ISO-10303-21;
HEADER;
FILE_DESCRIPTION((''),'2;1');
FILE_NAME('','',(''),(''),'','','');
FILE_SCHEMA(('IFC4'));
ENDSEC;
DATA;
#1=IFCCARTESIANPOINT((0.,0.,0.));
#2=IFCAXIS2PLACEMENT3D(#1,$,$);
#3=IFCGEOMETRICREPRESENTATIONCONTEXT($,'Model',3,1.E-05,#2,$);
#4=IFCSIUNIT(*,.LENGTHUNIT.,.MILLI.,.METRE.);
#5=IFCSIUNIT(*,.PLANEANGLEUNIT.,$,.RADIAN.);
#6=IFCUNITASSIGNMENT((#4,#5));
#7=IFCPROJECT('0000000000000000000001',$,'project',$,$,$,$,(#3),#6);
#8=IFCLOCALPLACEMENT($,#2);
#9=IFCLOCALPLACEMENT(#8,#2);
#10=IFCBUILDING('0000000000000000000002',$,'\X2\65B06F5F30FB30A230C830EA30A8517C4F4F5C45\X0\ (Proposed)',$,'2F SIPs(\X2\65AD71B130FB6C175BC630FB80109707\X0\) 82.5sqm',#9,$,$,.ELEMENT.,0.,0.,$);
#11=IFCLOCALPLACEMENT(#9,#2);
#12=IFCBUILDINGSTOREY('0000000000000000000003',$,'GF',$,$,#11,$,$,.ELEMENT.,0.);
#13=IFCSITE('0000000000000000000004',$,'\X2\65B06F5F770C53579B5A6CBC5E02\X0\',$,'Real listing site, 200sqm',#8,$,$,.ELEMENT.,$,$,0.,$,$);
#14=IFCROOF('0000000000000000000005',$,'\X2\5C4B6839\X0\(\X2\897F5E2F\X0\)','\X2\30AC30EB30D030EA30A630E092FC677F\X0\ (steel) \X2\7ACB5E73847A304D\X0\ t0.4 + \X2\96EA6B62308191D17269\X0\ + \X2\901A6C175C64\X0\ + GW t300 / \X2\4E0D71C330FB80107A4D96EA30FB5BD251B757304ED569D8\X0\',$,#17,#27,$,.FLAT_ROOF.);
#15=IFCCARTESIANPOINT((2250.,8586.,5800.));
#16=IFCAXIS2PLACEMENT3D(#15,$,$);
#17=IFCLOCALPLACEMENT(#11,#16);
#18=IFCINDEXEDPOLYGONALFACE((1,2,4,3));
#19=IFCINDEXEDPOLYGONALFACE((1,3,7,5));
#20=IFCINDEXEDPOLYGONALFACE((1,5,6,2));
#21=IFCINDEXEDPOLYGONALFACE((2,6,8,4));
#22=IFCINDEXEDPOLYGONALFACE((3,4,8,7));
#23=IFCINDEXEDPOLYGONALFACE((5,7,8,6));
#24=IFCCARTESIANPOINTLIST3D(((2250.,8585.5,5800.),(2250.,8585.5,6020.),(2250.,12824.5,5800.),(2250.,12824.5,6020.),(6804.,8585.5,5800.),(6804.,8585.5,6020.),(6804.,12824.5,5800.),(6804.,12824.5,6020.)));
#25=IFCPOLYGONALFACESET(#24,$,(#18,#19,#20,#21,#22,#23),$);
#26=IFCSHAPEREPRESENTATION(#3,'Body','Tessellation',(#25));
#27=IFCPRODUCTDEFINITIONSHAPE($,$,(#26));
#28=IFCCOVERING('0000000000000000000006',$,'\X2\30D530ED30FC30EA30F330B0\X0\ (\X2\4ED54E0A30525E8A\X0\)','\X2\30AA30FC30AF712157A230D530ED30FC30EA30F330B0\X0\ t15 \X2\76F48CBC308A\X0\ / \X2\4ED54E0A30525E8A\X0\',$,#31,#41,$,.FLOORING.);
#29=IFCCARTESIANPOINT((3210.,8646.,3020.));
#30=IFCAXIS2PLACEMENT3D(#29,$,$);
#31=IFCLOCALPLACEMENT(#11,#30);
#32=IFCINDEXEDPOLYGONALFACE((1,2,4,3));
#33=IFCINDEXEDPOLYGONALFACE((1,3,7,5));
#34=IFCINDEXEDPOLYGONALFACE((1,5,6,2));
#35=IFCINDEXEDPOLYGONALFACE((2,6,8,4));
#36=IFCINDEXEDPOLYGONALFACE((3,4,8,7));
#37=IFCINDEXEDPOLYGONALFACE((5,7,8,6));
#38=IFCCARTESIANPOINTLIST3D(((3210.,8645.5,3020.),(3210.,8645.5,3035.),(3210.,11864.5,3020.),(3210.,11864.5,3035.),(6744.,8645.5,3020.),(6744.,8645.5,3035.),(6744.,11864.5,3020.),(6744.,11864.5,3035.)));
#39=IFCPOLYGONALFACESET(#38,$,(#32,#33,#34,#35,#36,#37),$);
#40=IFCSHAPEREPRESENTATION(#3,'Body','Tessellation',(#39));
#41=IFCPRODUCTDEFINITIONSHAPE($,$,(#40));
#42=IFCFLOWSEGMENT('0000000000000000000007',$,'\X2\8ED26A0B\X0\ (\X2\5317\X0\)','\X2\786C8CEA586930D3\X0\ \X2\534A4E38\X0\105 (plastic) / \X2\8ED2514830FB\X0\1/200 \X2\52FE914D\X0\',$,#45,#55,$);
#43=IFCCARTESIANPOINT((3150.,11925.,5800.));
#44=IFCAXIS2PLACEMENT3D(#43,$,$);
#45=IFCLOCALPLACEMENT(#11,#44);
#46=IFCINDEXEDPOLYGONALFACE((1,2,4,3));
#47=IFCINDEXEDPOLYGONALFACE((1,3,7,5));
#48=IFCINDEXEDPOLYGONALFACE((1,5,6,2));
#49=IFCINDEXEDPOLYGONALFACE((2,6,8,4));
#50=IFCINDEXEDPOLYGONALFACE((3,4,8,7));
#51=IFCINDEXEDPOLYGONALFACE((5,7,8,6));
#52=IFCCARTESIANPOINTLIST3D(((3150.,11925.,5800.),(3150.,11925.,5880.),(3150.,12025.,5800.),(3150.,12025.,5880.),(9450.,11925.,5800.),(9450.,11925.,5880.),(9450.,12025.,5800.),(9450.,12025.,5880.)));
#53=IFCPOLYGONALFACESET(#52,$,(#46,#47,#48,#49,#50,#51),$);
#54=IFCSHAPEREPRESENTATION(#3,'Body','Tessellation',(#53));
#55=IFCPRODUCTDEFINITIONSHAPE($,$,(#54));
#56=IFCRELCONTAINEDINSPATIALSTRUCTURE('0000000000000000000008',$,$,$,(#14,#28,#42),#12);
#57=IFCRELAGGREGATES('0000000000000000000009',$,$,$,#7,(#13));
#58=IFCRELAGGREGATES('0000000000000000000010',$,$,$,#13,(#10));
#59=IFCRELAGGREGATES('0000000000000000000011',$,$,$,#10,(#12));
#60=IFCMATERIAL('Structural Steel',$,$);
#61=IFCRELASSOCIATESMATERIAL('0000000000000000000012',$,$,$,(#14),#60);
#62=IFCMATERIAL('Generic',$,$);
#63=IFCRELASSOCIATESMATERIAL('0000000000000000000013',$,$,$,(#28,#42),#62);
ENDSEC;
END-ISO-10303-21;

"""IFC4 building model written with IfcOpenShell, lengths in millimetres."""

from ifc_helpers import new_model, si_unit, frame, frame_2d, origin, place, context, project, spatial, rectangle, extrude, material, element, save


model = new_model("IFC4")

# Units and contexts
model_context = context("Model", 3, precision=1e-05, world=origin())
ifc_project = project(units=[si_unit("LENGTHUNIT", "METRE", prefix="MILLI"), si_unit("PLANEANGLEUNIT", "RADIAN")], contexts=[model_context])

# Site, building, storey
site_placement = place(None, origin())
site = spatial("IfcSite", under=ifc_project, at=site_placement, Name="新潟県南魚沼市", ObjectType="Real listing site, 200sqm", CompositionType="ELEMENT", RefElevation=0.0)
building_placement = place(site_placement, origin())
building = spatial("IfcBuilding", under=site, at=building_placement, Name="新潟・アトリエ兼住居 (Proposed)", ObjectType="2F SIPs(断熱・気密・耐震) 82.5sqm", CompositionType="ELEMENT", ElevationOfRefHeight=0.0, ElevationOfTerrain=0.0)
storey_placement = place(building_placement, origin())
storey = spatial("IfcBuildingStorey", under=building, at=storey_placement, Name="GF", CompositionType="ELEMENT", Elevation=0.0)

# Roof
ifc_material_1 = material(Name="Structural Steel")
for number, where, name in (
    (1, (2250.0, 8586.0, 5800.0), "屋根(西帯)"),
):
    element("IfcRoof", number, at=place(storey_placement, frame(where)), inside=storey, material=ifc_material_1, Name=name, Description="ガルバリウム鋼板 (steel) 立平葺き t0.4 + 雪止め金物 + 通気層 + GW t300 / 不燃・耐積雪・寒冷地仕様", PredefinedType="FLAT_ROOF", context=model_context, shape_type="SweptSolid", body=[
        extrude(rectangle(XDim=4554.0, YDim=4239.0, at=frame_2d((2277.0, 2119.0))), frame((2250.0, 8586.0, 5800.0)), (0.0, 0.0, 1.0), 220.0),
    ])

# Covering
ifc_material_2 = material(Name="Generic")
covering_placement = place(storey_placement, frame((3210.0, 8646.0, 3020.0)))
element("IfcCovering", 2, at=covering_placement, inside=storey, material=ifc_material_2, Name="フローリング (仕上げ床)", Description="オーク無垢フローリング t15 直貼り / 仕上げ床", PredefinedType="FLOORING", context=model_context, shape_type="SweptSolid", body=[
    extrude(rectangle(XDim=3534.0, YDim=3219.0, at=frame_2d((1767.0, 1609.0))), frame((3210.0, 8646.0, 3020.0)), (0.0, 0.0, 1.0), 15.0),
])

# Flow segment
flow_segment_placement = place(storey_placement, frame((3150.0, 11925.0, 5800.0)))
element("IfcFlowSegment", 3, at=flow_segment_placement, inside=storey, material=ifc_material_2, Name="軒樋 (北)", Description="硬質塩ビ 半丸105 (plastic) / 軒先・1/200 勾配", context=model_context, shape_type="SweptSolid", body=[
    extrude(rectangle(XDim=6300.0, YDim=100.0, at=frame_2d((3150.0, 50.0))), frame((3150.0, 11925.0, 5800.0)), (0.0, 0.0, 1.0), 80.0),
])

save(model, "model.ifc")
